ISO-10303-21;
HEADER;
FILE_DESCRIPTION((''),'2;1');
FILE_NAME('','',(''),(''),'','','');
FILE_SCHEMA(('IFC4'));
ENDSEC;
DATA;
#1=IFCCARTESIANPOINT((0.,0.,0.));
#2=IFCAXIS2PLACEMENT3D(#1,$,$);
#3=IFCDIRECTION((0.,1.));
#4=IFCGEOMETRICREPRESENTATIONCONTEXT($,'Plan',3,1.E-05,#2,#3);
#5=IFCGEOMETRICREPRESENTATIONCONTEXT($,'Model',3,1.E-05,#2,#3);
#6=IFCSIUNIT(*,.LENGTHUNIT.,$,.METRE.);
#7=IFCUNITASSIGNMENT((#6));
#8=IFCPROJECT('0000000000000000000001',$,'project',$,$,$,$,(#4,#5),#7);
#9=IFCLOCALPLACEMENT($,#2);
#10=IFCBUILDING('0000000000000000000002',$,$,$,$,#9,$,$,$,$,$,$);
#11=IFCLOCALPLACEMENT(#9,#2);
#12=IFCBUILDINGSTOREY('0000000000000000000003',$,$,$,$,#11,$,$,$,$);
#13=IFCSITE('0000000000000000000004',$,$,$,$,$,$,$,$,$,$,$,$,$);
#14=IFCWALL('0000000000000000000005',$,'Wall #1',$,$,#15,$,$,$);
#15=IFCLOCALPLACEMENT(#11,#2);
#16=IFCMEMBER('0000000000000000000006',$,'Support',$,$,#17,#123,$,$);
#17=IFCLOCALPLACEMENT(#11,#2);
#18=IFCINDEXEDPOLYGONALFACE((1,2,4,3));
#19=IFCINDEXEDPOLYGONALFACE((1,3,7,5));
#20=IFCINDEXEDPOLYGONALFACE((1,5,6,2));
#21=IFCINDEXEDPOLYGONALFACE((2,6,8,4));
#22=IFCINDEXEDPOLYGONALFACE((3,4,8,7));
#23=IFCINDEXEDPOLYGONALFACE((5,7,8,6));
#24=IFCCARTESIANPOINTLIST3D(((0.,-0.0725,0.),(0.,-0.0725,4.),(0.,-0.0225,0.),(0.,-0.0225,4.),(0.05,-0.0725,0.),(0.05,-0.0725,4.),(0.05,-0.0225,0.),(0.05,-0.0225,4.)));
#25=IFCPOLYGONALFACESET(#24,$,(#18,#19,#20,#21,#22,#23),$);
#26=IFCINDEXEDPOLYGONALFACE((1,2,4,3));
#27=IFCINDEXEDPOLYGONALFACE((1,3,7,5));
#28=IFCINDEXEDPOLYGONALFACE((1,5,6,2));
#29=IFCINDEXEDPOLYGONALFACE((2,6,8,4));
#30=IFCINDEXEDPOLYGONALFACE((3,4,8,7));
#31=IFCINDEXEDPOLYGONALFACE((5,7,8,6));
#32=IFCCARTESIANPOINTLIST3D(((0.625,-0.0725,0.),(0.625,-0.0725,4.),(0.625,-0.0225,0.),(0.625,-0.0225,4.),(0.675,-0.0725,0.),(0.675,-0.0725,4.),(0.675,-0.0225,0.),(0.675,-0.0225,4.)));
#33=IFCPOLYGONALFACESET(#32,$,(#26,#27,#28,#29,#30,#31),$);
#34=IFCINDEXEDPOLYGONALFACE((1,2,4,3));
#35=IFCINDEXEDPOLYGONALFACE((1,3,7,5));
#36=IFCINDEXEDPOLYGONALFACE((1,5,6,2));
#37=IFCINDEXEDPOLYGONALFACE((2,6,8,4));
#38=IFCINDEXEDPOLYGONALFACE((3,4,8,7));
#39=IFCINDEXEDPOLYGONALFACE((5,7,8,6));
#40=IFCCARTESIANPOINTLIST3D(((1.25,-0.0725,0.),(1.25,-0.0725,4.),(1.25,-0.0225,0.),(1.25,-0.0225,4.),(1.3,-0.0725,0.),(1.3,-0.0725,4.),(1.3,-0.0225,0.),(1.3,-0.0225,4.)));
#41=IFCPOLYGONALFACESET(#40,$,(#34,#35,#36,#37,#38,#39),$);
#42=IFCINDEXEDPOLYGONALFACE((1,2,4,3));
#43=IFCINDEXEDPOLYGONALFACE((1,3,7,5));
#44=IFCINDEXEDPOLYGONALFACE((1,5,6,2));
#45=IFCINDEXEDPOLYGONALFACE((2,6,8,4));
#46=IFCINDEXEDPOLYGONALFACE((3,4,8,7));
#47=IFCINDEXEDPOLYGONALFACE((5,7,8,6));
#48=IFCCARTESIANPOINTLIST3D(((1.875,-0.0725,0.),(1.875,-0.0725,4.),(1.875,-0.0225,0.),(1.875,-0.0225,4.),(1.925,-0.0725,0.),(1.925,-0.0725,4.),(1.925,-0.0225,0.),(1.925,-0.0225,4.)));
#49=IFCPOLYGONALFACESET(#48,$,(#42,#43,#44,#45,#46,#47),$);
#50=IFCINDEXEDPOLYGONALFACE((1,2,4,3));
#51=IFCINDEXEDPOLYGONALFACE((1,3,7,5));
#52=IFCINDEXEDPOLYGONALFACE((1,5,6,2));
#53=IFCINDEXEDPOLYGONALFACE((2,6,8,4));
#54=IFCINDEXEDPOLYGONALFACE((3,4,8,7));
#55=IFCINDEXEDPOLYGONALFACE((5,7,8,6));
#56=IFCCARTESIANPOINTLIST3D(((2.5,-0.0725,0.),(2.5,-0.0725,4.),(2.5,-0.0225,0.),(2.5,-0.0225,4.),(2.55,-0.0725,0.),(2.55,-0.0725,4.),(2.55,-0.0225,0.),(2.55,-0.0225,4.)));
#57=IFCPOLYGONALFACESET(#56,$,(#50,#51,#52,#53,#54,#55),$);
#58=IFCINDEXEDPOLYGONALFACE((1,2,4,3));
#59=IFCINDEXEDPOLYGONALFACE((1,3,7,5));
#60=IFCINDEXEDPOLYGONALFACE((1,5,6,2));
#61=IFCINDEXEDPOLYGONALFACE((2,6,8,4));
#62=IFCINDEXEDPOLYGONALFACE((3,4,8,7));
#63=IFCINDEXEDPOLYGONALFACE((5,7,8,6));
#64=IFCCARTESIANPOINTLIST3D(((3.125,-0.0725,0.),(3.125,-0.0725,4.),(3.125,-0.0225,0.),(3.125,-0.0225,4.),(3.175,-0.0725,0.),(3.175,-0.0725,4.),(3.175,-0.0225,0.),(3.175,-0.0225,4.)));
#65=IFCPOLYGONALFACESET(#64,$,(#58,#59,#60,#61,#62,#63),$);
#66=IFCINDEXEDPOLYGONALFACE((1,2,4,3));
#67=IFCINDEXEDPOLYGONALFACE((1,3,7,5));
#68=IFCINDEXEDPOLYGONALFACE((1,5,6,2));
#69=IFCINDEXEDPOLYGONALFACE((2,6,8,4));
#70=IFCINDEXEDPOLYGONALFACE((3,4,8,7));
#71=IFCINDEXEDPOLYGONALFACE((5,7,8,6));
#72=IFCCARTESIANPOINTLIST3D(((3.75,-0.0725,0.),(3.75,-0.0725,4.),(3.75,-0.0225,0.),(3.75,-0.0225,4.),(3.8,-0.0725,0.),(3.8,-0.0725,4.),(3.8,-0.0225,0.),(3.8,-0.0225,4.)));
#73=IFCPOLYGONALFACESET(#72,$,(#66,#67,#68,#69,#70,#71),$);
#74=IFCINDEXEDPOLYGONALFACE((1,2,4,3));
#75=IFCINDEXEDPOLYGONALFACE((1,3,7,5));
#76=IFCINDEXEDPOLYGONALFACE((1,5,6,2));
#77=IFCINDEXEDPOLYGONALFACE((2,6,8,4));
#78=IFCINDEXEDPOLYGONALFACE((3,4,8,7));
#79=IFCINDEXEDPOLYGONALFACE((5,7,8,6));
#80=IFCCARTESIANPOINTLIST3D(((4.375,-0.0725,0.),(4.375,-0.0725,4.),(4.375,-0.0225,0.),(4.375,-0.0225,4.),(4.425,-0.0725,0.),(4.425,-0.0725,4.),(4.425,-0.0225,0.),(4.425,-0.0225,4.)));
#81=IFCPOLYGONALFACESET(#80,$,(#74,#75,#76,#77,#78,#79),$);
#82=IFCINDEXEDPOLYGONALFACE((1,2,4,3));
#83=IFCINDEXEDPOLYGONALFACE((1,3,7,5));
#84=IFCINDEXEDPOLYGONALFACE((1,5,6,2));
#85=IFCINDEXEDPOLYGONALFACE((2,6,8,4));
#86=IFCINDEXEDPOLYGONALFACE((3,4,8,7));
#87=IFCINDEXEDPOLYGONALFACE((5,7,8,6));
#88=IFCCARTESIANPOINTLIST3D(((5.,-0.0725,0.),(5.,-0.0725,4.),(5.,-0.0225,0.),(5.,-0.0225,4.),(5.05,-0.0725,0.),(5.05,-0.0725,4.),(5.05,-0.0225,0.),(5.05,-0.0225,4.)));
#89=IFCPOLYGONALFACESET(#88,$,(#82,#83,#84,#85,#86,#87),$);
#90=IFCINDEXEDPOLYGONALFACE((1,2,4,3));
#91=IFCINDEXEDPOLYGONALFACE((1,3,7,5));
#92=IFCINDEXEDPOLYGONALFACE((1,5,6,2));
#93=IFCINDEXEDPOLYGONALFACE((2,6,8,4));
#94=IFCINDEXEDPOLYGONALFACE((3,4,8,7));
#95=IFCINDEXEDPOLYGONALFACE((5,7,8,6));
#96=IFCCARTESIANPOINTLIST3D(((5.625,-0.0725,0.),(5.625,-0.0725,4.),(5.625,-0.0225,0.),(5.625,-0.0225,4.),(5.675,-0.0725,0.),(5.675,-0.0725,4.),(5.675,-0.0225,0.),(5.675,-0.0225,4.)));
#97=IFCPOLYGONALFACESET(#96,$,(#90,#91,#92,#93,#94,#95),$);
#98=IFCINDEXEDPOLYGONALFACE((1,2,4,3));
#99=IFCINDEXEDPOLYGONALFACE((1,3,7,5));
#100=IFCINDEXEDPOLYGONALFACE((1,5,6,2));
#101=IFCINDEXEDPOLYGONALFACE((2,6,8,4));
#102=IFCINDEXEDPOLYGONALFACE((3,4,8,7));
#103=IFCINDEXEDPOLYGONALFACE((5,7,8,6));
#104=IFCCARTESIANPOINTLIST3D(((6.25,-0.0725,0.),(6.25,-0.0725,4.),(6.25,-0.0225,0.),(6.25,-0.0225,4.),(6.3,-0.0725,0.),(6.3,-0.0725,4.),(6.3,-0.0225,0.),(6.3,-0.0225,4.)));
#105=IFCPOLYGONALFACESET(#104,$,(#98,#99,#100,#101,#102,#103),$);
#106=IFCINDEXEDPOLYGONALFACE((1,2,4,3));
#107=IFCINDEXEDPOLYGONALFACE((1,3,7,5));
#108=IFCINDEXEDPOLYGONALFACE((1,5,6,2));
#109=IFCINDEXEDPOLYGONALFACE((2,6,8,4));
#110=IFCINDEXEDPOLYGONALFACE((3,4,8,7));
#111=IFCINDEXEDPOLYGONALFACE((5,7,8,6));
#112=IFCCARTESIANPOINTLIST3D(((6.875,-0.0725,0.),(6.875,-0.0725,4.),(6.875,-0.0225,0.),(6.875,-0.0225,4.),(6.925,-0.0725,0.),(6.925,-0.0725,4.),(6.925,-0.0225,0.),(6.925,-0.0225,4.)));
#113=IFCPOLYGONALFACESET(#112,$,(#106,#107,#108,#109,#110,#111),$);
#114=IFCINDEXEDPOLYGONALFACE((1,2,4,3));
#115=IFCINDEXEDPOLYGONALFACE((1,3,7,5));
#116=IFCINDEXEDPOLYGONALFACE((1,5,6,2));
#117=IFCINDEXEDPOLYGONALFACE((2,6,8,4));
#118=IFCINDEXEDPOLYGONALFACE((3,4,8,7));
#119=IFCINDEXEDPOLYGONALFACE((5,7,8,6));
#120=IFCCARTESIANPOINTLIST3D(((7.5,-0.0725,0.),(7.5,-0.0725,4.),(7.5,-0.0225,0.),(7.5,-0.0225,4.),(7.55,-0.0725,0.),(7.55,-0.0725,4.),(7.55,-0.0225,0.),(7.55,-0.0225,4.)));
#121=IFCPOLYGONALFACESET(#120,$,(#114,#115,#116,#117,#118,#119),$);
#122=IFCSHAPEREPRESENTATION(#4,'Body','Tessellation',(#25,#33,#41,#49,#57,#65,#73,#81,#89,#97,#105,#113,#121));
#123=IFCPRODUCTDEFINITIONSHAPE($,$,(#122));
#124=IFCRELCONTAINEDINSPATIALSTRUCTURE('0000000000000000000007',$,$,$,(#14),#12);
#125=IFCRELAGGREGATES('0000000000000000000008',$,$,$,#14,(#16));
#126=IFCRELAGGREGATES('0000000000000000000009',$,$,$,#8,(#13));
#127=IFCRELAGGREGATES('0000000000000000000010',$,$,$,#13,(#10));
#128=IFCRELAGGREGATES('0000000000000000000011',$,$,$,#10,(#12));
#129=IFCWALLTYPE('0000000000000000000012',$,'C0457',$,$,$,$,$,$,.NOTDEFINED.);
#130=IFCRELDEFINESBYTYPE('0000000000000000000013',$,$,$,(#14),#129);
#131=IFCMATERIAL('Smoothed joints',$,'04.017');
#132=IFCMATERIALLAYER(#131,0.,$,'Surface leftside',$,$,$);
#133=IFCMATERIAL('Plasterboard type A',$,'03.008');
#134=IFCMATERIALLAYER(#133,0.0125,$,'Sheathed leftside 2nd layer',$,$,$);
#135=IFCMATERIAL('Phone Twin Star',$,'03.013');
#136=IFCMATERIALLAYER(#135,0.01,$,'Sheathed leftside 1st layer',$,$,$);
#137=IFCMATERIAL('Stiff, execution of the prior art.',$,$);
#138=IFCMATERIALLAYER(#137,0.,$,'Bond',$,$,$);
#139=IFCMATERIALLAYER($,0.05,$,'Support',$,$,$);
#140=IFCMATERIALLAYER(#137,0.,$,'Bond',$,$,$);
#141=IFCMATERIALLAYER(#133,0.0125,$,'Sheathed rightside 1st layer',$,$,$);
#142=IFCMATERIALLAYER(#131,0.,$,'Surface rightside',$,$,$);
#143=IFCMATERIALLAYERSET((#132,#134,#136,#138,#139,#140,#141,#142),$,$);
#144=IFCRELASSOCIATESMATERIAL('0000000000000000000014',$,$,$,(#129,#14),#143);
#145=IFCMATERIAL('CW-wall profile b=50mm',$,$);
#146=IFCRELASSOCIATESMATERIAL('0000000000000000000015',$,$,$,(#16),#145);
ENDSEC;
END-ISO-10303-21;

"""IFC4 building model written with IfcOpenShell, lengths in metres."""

from ifc_helpers import new_model, si_unit, direction, frame, frame_2d, origin, place, context, project, spatial, rectangle, extrude, material, layer, layer_set, type_object, element, aggregate, save


model = new_model("IFC4")

# Units and contexts
plan_context = context("Plan", 3, precision=1e-05, world=origin(), true_north=direction((0.0, 1.0)))
model_context = context("Model", 3, precision=1e-05, world=origin(), true_north=direction((0.0, 1.0)))
ifc_project = project(units=[si_unit("LENGTHUNIT", "METRE")], contexts=[plan_context, model_context])

# Site, building, storey
site = spatial("IfcSite", under=ifc_project)
building_placement = place(None, origin())
building = spatial("IfcBuilding", under=site, at=building_placement)
storey_placement = place(building_placement, origin())
storey = spatial("IfcBuildingStorey", under=building, at=storey_placement)

# Wall, member
ifc_material_1 = material(Name="Smoothed joints", Category="04.017")
ifc_layer_1 = layer(ifc_material_1, 0.0, Name="Surface leftside")
ifc_material_2 = material(Name="Plasterboard type A", Category="03.008")
ifc_layer_2 = layer(ifc_material_2, 0.0125, Name="Sheathed leftside 2nd layer")
ifc_material_3 = material(Name="Phone Twin Star", Category="03.013")
ifc_layer_3 = layer(ifc_material_3, 0.01, Name="Sheathed leftside 1st layer")
ifc_material_4 = material(Name="Stiff, execution of the prior art.")
ifc_layer_4 = layer(ifc_material_4, 0.0, Name="Bond")
ifc_layer_5 = layer(None, 0.05, Name="Support")
ifc_layer_6 = layer(ifc_material_4, 0.0, Name="Bond")
ifc_layer_7 = layer(ifc_material_2, 0.0125, Name="Sheathed rightside 1st layer")
ifc_layer_8 = layer(ifc_material_1, 0.0, Name="Surface rightside")
ifc_layer_set = layer_set([ifc_layer_1, ifc_layer_2, ifc_layer_3, ifc_layer_4, ifc_layer_5, ifc_layer_6, ifc_layer_7, ifc_layer_8])
wall_type = type_object("IfcWallType", Name="C0457", PredefinedType="NOTDEFINED", material=ifc_layer_set)
wall_placement = place(None, frame((0.0, 0.0, 0.0), z_axis=(0.0, -1.0, 0.0), x_axis=(1.0, 0.0, 0.0)))
wall = element("IfcWall", 1, at=wall_placement, inside=storey, type_object=wall_type, material=ifc_layer_set, Name="Wall #1")
ifc_material_5 = material(Name="CW-wall profile b=50mm")
member_1_placement = place(wall_placement, origin())
member_1 = element("IfcMember", 2, at=member_1_placement, material=ifc_material_5, Name="Support", context=plan_context, shape_type="SweptSolid", body=[
    extrude(rectangle(XDim=0.05, YDim=0.05, at=frame_2d((0.025, 0.025), x_axis=(1.0, 0.0))), frame((0.0, 4.0, 0.0225), z_axis=(0.0, -1.0, 0.0), x_axis=(1.0, 0.0, 0.0)), (0.0, 0.0, 1.0), 4.0),
    extrude(rectangle(XDim=0.05, YDim=0.05, at=frame_2d((0.025, 0.025), x_axis=(1.0, 0.0))), frame((0.625, 4.0, 0.0225), z_axis=(0.0, -1.0, 0.0), x_axis=(1.0, 0.0, 0.0)), (0.0, 0.0, 1.0), 4.0),
    extrude(rectangle(XDim=0.05, YDim=0.05, at=frame_2d((0.025, 0.025), x_axis=(1.0, 0.0))), frame((1.25, 4.0, 0.0225), z_axis=(0.0, -1.0, 0.0), x_axis=(1.0, 0.0, 0.0)), (0.0, 0.0, 1.0), 4.0),
    extrude(rectangle(XDim=0.05, YDim=0.05, at=frame_2d((0.025, 0.025), x_axis=(1.0, 0.0))), frame((1.875, 4.0, 0.0225), z_axis=(0.0, -1.0, 0.0), x_axis=(1.0, 0.0, 0.0)), (0.0, 0.0, 1.0), 4.0),
    extrude(rectangle(XDim=0.05, YDim=0.05, at=frame_2d((0.025, 0.025), x_axis=(1.0, 0.0))), frame((2.5, 4.0, 0.0225), z_axis=(0.0, -1.0, 0.0), x_axis=(1.0, 0.0, 0.0)), (0.0, 0.0, 1.0), 4.0),
    extrude(rectangle(XDim=0.05, YDim=0.05, at=frame_2d((0.025, 0.025), x_axis=(1.0, 0.0))), frame((3.125, 4.0, 0.0225), z_axis=(0.0, -1.0, 0.0), x_axis=(1.0, 0.0, 0.0)), (0.0, 0.0, 1.0), 4.0),
    extrude(rectangle(XDim=0.05, YDim=0.05, at=frame_2d((0.025, 0.025), x_axis=(1.0, 0.0))), frame((3.75, 4.0, 0.0225), z_axis=(0.0, -1.0, 0.0), x_axis=(1.0, 0.0, 0.0)), (0.0, 0.0, 1.0), 4.0),
    extrude(rectangle(XDim=0.05, YDim=0.05, at=frame_2d((0.025, 0.025), x_axis=(1.0, 0.0))), frame((4.375, 4.0, 0.0225), z_axis=(0.0, -1.0, 0.0), x_axis=(1.0, 0.0, 0.0)), (0.0, 0.0, 1.0), 4.0),
    extrude(rectangle(XDim=0.05, YDim=0.05, at=frame_2d((0.025, 0.025), x_axis=(1.0, 0.0))), frame((5.0, 4.0, 0.0225), z_axis=(0.0, -1.0, 0.0), x_axis=(1.0, 0.0, 0.0)), (0.0, 0.0, 1.0), 4.0),
    extrude(rectangle(XDim=0.05, YDim=0.05, at=frame_2d((0.025, 0.025), x_axis=(1.0, 0.0))), frame((5.625, 4.0, 0.0225), z_axis=(0.0, -1.0, 0.0), x_axis=(1.0, 0.0, 0.0)), (0.0, 0.0, 1.0), 4.0),
    extrude(rectangle(XDim=0.05, YDim=0.05, at=frame_2d((0.025, 0.025), x_axis=(1.0, 0.0))), frame((6.25, 4.0, 0.0225), z_axis=(0.0, -1.0, 0.0), x_axis=(1.0, 0.0, 0.0)), (0.0, 0.0, 1.0), 4.0),
    extrude(rectangle(XDim=0.05, YDim=0.05, at=frame_2d((0.025, 0.025), x_axis=(1.0, 0.0))), frame((6.875, 4.0, 0.0225), z_axis=(0.0, -1.0, 0.0), x_axis=(1.0, 0.0, 0.0)), (0.0, 0.0, 1.0), 4.0),
    extrude(rectangle(XDim=0.05, YDim=0.05, at=frame_2d((0.025, 0.025), x_axis=(1.0, 0.0))), frame((7.5, 4.0, 0.0225), z_axis=(0.0, -1.0, 0.0), x_axis=(1.0, 0.0, 0.0)), (0.0, 0.0, 1.0), 4.0),
])
aggregate(wall, [member_1])

save(model, "model.ifc")
